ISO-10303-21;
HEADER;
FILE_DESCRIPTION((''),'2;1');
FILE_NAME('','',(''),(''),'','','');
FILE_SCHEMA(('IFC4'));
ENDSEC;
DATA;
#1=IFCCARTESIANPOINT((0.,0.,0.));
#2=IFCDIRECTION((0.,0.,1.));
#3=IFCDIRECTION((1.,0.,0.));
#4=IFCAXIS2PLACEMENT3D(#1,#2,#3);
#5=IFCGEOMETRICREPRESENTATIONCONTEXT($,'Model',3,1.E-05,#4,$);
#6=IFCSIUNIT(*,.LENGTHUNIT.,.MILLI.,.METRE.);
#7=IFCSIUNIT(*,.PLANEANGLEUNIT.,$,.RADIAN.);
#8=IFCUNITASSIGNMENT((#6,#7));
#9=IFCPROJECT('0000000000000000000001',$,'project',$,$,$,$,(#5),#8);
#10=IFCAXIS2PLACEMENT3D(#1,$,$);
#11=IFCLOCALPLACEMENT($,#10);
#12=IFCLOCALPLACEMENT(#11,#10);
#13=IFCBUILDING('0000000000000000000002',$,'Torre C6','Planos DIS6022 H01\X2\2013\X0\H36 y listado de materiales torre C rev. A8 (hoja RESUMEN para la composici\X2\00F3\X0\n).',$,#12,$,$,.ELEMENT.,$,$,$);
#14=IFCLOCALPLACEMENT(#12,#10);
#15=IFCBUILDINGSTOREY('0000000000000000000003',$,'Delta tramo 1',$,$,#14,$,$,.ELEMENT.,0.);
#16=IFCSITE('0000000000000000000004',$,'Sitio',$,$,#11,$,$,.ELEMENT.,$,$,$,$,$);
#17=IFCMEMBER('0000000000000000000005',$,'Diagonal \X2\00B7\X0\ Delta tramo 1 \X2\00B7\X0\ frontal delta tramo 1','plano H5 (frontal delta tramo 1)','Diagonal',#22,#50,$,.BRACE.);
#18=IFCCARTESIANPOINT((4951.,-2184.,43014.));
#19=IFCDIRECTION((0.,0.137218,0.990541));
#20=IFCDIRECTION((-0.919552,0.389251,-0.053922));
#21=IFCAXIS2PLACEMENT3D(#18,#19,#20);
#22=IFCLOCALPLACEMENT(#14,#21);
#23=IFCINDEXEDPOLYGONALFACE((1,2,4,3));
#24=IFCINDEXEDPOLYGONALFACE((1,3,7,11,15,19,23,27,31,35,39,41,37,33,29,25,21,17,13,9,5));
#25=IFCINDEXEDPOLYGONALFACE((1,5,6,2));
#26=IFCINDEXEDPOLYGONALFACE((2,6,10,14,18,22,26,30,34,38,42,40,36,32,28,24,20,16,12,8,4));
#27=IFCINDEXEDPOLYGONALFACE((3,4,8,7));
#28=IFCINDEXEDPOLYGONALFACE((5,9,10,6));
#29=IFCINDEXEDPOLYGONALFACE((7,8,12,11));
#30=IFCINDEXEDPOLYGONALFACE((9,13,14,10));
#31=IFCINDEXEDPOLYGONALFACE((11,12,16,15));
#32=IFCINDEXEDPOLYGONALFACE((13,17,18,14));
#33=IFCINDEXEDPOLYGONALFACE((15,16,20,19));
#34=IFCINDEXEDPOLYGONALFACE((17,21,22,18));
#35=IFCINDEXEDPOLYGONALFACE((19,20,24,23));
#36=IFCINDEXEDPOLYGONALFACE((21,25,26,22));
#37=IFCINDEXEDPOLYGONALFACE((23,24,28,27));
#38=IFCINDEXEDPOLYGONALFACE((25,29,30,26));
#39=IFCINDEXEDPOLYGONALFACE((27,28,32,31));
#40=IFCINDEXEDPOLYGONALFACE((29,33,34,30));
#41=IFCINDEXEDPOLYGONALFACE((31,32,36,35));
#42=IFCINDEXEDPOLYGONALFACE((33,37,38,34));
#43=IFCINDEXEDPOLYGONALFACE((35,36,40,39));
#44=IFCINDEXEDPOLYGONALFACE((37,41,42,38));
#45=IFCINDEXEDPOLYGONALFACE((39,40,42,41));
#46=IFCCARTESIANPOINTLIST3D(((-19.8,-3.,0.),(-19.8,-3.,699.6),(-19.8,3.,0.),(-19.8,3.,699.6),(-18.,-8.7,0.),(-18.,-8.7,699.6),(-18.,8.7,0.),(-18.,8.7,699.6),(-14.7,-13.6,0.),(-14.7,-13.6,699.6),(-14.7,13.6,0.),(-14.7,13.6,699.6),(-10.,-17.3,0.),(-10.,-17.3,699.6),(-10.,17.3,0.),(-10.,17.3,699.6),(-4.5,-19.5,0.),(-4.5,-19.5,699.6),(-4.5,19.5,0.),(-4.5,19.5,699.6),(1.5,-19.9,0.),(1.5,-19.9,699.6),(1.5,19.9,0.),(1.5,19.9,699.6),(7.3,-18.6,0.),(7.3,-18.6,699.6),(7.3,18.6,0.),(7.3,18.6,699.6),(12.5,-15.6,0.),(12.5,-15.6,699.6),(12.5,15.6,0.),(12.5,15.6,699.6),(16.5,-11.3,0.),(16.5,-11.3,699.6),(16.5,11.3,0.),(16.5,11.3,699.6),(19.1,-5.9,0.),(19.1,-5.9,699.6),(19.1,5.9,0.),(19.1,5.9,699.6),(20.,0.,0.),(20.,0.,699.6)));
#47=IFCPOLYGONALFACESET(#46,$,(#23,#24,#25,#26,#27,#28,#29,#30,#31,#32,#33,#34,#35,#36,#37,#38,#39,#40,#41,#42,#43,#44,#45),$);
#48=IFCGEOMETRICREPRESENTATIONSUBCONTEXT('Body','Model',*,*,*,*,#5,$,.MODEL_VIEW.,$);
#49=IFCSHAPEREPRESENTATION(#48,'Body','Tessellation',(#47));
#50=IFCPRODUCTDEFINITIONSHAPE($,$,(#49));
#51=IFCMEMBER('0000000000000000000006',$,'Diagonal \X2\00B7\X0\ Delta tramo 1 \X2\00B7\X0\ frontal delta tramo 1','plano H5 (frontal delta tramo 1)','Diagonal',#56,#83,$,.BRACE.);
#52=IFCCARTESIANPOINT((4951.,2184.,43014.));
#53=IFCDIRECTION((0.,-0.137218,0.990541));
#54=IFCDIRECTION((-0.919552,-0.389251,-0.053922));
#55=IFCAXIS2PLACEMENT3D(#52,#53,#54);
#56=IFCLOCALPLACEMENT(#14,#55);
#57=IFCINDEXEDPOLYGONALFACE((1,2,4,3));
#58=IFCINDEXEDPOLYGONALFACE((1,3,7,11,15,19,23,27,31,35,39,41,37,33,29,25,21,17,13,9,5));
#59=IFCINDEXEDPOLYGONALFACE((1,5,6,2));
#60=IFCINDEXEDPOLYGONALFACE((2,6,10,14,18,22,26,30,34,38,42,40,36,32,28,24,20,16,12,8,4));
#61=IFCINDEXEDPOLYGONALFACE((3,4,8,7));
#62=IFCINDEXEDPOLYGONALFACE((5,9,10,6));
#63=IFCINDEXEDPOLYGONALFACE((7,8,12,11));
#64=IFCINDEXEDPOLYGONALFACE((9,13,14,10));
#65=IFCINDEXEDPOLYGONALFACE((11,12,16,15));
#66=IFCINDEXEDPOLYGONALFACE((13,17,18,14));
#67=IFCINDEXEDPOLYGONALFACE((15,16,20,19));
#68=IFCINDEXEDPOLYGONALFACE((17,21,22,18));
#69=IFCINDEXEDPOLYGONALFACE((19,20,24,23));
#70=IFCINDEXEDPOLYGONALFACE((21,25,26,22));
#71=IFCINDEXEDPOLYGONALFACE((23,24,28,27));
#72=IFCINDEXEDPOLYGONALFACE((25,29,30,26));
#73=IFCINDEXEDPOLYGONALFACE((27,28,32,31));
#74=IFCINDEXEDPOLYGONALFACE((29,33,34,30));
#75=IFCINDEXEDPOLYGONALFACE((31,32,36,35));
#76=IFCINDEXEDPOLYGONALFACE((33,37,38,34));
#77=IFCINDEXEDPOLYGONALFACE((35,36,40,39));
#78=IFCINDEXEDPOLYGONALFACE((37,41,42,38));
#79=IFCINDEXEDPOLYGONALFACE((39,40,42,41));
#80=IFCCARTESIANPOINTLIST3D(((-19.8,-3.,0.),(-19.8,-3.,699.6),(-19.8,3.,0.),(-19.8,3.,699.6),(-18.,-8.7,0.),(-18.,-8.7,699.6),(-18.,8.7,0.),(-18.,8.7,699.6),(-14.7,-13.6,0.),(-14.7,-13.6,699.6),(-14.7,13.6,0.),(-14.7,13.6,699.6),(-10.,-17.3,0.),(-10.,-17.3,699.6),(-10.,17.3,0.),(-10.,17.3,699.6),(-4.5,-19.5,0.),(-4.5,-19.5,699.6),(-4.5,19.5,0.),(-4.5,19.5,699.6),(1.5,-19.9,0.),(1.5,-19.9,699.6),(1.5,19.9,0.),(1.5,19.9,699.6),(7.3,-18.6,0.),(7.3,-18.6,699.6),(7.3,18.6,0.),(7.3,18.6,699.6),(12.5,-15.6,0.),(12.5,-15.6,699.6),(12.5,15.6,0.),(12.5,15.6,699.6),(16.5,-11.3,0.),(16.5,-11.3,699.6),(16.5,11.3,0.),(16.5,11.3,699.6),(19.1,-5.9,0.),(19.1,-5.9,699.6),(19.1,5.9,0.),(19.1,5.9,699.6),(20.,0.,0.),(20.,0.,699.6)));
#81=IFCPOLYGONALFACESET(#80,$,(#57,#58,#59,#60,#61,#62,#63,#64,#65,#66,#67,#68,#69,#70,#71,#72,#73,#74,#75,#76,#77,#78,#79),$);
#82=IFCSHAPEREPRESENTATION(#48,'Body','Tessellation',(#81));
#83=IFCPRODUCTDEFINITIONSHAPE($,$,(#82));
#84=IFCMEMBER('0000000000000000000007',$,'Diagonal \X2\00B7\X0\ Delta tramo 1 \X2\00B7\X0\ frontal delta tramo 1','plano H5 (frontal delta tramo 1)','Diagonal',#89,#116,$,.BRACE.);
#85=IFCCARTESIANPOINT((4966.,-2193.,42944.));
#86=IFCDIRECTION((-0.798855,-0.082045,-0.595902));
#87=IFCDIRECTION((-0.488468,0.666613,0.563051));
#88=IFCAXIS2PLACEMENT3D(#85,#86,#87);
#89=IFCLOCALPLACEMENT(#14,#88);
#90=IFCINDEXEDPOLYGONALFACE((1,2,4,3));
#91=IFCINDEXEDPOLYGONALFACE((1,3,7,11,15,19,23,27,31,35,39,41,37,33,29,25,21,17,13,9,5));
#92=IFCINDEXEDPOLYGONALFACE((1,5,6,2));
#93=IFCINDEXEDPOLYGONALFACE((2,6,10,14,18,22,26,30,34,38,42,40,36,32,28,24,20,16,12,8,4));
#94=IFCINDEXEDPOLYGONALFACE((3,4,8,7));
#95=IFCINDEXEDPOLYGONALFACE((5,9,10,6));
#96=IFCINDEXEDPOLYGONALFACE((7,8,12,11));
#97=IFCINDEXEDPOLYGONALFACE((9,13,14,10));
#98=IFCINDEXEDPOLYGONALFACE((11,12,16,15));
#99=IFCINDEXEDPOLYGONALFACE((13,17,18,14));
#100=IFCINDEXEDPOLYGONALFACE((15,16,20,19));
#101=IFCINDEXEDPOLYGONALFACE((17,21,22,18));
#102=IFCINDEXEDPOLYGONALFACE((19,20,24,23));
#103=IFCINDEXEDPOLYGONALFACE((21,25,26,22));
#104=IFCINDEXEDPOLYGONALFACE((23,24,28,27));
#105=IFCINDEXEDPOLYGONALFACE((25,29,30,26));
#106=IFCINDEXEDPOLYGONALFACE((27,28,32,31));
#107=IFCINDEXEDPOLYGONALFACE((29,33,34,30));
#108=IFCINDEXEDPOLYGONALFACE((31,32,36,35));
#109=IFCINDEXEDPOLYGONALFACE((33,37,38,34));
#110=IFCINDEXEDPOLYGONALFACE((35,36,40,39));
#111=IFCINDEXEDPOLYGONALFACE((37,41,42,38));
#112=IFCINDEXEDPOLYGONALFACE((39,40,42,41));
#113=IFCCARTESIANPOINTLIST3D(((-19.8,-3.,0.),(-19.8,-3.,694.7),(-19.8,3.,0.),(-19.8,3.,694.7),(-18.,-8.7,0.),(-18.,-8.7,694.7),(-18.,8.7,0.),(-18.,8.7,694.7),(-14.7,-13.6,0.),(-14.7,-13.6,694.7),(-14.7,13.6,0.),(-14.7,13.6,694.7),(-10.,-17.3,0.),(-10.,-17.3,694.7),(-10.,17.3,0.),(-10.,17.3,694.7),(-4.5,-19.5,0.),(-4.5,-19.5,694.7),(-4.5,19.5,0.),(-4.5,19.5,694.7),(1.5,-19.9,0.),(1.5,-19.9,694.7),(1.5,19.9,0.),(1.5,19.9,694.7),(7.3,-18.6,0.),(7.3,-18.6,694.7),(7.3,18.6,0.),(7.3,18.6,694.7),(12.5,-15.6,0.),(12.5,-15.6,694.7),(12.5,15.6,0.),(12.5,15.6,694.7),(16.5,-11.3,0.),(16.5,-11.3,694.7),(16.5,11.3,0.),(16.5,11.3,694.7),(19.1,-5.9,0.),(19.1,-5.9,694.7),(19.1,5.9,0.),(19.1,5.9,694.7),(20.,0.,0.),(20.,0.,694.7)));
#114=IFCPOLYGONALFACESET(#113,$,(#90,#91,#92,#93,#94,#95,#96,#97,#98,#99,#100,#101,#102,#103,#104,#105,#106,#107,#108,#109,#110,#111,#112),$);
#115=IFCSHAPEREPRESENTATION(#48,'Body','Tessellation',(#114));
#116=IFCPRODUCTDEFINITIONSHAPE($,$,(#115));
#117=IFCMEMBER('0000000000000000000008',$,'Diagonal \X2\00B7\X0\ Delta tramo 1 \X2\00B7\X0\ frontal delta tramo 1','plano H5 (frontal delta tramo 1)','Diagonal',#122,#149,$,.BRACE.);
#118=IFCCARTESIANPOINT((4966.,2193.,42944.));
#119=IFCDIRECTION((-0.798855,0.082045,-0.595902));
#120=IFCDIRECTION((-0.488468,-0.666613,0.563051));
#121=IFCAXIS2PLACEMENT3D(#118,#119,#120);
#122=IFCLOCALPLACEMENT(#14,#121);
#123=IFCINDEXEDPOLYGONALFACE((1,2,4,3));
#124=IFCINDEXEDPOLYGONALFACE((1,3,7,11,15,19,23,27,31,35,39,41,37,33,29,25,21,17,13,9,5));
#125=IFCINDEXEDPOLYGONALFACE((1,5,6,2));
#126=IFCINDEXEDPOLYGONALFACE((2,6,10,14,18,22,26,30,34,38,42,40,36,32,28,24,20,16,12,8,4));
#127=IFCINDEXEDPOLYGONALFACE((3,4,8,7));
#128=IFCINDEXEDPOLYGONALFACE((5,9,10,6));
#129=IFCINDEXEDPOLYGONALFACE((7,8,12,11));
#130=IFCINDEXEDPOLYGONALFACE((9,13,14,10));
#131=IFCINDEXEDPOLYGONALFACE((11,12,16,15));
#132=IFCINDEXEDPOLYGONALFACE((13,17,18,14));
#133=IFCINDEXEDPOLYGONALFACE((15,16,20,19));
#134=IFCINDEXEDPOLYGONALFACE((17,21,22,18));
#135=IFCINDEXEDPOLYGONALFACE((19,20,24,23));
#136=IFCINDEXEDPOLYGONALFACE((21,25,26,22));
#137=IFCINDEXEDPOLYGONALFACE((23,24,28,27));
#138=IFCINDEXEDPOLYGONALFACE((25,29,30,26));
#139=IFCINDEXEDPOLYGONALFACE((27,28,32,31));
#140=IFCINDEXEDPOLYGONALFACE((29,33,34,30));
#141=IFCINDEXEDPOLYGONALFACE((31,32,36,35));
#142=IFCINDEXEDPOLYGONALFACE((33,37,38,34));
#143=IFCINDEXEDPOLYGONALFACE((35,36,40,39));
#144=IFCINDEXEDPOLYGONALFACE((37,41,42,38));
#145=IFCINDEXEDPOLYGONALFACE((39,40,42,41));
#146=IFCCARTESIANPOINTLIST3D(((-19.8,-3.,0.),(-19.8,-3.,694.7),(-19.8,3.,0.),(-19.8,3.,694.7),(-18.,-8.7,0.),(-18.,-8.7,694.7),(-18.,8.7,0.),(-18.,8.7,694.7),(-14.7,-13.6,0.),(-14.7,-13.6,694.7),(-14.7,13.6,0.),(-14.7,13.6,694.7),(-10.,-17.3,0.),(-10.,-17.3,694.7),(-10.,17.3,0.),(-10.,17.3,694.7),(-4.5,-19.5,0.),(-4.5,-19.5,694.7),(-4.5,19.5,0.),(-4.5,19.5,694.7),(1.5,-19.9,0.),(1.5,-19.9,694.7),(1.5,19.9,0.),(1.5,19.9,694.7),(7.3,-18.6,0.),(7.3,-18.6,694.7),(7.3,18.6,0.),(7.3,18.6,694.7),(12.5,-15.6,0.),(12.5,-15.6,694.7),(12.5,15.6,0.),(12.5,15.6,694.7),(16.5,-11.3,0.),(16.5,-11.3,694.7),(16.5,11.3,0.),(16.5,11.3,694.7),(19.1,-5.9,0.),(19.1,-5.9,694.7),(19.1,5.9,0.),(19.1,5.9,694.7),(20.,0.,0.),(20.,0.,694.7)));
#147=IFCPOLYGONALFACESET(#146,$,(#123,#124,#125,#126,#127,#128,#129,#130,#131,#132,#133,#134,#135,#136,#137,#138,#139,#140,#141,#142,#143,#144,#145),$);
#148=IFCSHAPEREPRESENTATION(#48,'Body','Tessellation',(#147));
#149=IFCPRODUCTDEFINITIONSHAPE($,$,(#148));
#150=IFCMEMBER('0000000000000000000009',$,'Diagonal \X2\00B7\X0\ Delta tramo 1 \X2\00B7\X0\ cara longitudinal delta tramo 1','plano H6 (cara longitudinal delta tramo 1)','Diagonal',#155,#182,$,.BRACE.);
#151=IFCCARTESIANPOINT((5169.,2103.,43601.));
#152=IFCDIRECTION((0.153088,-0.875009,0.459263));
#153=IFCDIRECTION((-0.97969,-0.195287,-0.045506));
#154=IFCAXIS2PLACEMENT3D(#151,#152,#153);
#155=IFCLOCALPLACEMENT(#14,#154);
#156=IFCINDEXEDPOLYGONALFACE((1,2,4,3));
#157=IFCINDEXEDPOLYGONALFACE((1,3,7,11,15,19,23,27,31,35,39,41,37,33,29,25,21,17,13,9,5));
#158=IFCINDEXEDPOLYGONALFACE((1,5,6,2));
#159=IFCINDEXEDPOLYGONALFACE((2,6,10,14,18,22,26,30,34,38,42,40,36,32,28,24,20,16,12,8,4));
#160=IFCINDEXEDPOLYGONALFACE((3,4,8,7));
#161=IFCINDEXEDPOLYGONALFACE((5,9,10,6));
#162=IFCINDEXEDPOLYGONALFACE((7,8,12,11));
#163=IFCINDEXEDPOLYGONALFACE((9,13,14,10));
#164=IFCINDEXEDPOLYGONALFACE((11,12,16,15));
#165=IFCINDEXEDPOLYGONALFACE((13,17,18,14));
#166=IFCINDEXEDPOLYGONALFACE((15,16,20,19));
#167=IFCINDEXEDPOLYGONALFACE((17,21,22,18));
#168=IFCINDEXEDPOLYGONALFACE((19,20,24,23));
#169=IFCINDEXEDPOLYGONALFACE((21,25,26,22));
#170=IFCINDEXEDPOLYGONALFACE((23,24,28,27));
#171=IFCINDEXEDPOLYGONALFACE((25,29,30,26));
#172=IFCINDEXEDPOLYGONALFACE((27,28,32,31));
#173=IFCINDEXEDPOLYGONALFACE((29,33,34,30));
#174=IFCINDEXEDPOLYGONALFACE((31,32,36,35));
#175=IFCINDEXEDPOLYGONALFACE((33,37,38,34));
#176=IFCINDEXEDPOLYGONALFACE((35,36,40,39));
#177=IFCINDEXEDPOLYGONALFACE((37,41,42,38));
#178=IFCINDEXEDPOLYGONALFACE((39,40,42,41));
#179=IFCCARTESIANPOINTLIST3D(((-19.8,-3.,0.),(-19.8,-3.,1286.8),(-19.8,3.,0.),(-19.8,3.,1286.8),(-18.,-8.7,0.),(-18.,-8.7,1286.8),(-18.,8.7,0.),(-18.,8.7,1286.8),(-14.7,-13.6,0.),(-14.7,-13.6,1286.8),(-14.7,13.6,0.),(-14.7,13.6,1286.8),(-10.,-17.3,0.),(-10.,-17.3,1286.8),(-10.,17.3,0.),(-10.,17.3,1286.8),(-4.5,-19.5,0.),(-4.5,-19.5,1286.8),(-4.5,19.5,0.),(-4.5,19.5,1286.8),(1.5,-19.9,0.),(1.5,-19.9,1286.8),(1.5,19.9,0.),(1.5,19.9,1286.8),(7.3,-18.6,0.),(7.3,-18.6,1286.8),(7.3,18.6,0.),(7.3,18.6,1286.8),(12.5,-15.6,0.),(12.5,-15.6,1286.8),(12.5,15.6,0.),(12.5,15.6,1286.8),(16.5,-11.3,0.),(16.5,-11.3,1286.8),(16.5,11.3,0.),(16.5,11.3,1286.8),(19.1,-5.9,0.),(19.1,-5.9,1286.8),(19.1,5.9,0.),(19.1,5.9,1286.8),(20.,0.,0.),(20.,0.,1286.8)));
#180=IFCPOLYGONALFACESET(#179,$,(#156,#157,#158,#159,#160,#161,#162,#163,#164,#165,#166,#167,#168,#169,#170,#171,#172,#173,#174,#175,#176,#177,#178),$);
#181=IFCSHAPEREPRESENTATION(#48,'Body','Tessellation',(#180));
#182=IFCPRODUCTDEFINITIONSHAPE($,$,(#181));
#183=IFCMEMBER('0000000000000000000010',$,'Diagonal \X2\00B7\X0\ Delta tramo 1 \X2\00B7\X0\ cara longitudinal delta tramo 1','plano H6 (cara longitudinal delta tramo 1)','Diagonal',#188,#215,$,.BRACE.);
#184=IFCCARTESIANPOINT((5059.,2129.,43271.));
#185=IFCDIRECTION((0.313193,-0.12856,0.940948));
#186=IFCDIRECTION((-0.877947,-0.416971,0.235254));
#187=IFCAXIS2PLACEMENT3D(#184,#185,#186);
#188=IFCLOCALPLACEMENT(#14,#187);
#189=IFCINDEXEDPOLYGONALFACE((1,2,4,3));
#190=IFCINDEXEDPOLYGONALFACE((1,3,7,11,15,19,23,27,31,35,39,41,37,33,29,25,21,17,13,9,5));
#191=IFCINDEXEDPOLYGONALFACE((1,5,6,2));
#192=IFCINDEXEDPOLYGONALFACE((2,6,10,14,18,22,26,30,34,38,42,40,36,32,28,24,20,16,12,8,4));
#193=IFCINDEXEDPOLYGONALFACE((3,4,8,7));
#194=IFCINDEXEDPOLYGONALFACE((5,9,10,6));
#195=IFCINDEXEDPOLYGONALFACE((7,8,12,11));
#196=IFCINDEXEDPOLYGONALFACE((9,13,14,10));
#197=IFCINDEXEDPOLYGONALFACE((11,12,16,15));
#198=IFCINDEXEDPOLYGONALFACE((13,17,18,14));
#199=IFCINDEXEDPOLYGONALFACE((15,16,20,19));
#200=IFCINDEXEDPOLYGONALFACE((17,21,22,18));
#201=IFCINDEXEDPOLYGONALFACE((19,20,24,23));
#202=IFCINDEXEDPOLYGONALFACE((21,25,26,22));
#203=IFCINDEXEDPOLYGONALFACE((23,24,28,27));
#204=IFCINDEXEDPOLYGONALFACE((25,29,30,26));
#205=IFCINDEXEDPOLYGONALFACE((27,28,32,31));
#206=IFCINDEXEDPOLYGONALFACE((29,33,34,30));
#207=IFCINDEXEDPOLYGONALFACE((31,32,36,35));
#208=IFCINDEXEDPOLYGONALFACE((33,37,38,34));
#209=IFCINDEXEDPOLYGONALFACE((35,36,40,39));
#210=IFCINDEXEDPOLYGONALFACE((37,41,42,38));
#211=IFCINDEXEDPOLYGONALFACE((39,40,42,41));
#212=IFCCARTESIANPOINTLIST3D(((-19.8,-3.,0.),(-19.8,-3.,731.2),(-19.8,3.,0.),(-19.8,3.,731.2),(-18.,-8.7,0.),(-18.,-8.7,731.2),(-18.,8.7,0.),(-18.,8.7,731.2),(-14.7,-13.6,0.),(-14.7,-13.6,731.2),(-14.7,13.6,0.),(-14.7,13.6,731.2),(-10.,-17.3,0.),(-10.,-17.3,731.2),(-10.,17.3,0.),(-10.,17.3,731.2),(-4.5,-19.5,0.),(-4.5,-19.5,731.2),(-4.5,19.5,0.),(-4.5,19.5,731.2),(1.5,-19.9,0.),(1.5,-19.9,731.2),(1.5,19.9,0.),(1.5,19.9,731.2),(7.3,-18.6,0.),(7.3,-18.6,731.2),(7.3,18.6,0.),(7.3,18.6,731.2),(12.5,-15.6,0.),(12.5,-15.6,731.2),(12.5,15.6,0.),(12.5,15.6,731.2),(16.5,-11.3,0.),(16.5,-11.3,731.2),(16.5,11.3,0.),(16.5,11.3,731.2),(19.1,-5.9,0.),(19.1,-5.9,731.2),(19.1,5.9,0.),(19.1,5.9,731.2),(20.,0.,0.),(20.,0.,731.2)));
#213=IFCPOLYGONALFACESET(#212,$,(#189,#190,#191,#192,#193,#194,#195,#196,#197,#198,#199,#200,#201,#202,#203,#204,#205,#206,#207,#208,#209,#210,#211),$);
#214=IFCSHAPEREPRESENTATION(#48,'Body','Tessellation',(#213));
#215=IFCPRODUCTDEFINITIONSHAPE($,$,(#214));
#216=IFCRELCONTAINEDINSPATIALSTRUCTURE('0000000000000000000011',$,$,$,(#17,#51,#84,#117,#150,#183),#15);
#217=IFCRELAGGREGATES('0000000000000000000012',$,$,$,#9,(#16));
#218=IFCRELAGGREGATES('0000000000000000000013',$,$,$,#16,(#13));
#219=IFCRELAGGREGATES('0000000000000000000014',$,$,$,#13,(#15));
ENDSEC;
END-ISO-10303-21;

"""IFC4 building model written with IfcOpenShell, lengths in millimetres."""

from ifc_helpers import new_model, si_unit, frame, origin, origin_with_axes, place, context, subcontext, project, spatial, circle, extrude, element, save


model = new_model("IFC4")

# Units and contexts
model_context = context("Model", 3, precision=1e-05, world=origin_with_axes())
body_context = subcontext(model_context, "Body", "Model", "MODEL_VIEW")
ifc_project = project(units=[si_unit("LENGTHUNIT", "METRE", prefix="MILLI"), si_unit("PLANEANGLEUNIT", "RADIAN")], contexts=[model_context])

# Site, building, storey
site_placement = place(None, origin())
site = spatial("IfcSite", under=ifc_project, at=site_placement, Name="Sitio", CompositionType="ELEMENT")
building_placement = place(site_placement, origin())
building = spatial("IfcBuilding", under=site, at=building_placement, Name="Torre C6", Description="Planos DIS6022 H01–H36 y listado de materiales torre C rev. A8 (hoja RESUMEN para la composición).", CompositionType="ELEMENT")
storey_placement = place(building_placement, origin())
storey = spatial("IfcBuildingStorey", under=building, at=storey_placement, Name="Delta tramo 1", CompositionType="ELEMENT", Elevation=0.0)

# Members
for number, where, z_axis, x_axis, name in (
    (1, (4951.0, -2184.0, 43014.0), (0.0, 0.137218, 0.990541), (-0.919552, 0.389251, -0.053922), "Diagonal · Delta tramo 1 · frontal delta tramo 1"),
    (2, (4951.0, 2184.0, 43014.0), (0.0, -0.137218, 0.990541), (-0.919552, -0.389251, -0.053922), "Diagonal · Delta tramo 1 · frontal delta tramo 1"),
):
    element("IfcMember", number, at=place(storey_placement, frame(where, z_axis=z_axis, x_axis=x_axis)), inside=storey, Name=name, Description="plano H5 (frontal delta tramo 1)", ObjectType="Diagonal", PredefinedType="BRACE", context=body_context, shape_type="SweptSolid", body=[
        extrude(circle(Radius=20.0), None, (0.0, 0.0, 1.0), 699.6),
    ])
for number, where, z_axis, x_axis, name in (
    (3, (4966.0, -2193.0, 42944.0), (-0.798855, -0.082045, -0.595902), (-0.488468, 0.666613, 0.563051), "Diagonal · Delta tramo 1 · frontal delta tramo 1"),
    (4, (4966.0, 2193.0, 42944.0), (-0.798855, 0.082045, -0.595902), (-0.488468, -0.666613, 0.563051), "Diagonal · Delta tramo 1 · frontal delta tramo 1"),
):
    element("IfcMember", number, at=place(storey_placement, frame(where, z_axis=z_axis, x_axis=x_axis)), inside=storey, Name=name, Description="plano H5 (frontal delta tramo 1)", ObjectType="Diagonal", PredefinedType="BRACE", context=body_context, shape_type="SweptSolid", body=[
        extrude(circle(Radius=20.0), None, (0.0, 0.0, 1.0), 694.7),
    ])
member_1_placement = place(storey_placement, frame((5169.0, 2103.0, 43601.0), z_axis=(0.153088, -0.875009, 0.459263), x_axis=(-0.97969, -0.195287, -0.045506)))
element("IfcMember", 5, at=member_1_placement, inside=storey, Name="Diagonal · Delta tramo 1 · cara longitudinal delta tramo 1", Description="plano H6 (cara longitudinal delta tramo 1)", ObjectType="Diagonal", PredefinedType="BRACE", context=body_context, shape_type="SweptSolid", body=[
    extrude(circle(Radius=20.0), None, (0.0, 0.0, 1.0), 1286.8),
])
member_2_placement = place(storey_placement, frame((5059.0, 2129.0, 43271.0), z_axis=(0.313193, -0.12856, 0.940948), x_axis=(-0.877947, -0.416971, 0.235254)))
element("IfcMember", 6, at=member_2_placement, inside=storey, Name="Diagonal · Delta tramo 1 · cara longitudinal delta tramo 1", Description="plano H6 (cara longitudinal delta tramo 1)", ObjectType="Diagonal", PredefinedType="BRACE", context=body_context, shape_type="SweptSolid", body=[
    extrude(circle(Radius=20.0), None, (0.0, 0.0, 1.0), 731.2),
])

save(model, "model.ifc")
